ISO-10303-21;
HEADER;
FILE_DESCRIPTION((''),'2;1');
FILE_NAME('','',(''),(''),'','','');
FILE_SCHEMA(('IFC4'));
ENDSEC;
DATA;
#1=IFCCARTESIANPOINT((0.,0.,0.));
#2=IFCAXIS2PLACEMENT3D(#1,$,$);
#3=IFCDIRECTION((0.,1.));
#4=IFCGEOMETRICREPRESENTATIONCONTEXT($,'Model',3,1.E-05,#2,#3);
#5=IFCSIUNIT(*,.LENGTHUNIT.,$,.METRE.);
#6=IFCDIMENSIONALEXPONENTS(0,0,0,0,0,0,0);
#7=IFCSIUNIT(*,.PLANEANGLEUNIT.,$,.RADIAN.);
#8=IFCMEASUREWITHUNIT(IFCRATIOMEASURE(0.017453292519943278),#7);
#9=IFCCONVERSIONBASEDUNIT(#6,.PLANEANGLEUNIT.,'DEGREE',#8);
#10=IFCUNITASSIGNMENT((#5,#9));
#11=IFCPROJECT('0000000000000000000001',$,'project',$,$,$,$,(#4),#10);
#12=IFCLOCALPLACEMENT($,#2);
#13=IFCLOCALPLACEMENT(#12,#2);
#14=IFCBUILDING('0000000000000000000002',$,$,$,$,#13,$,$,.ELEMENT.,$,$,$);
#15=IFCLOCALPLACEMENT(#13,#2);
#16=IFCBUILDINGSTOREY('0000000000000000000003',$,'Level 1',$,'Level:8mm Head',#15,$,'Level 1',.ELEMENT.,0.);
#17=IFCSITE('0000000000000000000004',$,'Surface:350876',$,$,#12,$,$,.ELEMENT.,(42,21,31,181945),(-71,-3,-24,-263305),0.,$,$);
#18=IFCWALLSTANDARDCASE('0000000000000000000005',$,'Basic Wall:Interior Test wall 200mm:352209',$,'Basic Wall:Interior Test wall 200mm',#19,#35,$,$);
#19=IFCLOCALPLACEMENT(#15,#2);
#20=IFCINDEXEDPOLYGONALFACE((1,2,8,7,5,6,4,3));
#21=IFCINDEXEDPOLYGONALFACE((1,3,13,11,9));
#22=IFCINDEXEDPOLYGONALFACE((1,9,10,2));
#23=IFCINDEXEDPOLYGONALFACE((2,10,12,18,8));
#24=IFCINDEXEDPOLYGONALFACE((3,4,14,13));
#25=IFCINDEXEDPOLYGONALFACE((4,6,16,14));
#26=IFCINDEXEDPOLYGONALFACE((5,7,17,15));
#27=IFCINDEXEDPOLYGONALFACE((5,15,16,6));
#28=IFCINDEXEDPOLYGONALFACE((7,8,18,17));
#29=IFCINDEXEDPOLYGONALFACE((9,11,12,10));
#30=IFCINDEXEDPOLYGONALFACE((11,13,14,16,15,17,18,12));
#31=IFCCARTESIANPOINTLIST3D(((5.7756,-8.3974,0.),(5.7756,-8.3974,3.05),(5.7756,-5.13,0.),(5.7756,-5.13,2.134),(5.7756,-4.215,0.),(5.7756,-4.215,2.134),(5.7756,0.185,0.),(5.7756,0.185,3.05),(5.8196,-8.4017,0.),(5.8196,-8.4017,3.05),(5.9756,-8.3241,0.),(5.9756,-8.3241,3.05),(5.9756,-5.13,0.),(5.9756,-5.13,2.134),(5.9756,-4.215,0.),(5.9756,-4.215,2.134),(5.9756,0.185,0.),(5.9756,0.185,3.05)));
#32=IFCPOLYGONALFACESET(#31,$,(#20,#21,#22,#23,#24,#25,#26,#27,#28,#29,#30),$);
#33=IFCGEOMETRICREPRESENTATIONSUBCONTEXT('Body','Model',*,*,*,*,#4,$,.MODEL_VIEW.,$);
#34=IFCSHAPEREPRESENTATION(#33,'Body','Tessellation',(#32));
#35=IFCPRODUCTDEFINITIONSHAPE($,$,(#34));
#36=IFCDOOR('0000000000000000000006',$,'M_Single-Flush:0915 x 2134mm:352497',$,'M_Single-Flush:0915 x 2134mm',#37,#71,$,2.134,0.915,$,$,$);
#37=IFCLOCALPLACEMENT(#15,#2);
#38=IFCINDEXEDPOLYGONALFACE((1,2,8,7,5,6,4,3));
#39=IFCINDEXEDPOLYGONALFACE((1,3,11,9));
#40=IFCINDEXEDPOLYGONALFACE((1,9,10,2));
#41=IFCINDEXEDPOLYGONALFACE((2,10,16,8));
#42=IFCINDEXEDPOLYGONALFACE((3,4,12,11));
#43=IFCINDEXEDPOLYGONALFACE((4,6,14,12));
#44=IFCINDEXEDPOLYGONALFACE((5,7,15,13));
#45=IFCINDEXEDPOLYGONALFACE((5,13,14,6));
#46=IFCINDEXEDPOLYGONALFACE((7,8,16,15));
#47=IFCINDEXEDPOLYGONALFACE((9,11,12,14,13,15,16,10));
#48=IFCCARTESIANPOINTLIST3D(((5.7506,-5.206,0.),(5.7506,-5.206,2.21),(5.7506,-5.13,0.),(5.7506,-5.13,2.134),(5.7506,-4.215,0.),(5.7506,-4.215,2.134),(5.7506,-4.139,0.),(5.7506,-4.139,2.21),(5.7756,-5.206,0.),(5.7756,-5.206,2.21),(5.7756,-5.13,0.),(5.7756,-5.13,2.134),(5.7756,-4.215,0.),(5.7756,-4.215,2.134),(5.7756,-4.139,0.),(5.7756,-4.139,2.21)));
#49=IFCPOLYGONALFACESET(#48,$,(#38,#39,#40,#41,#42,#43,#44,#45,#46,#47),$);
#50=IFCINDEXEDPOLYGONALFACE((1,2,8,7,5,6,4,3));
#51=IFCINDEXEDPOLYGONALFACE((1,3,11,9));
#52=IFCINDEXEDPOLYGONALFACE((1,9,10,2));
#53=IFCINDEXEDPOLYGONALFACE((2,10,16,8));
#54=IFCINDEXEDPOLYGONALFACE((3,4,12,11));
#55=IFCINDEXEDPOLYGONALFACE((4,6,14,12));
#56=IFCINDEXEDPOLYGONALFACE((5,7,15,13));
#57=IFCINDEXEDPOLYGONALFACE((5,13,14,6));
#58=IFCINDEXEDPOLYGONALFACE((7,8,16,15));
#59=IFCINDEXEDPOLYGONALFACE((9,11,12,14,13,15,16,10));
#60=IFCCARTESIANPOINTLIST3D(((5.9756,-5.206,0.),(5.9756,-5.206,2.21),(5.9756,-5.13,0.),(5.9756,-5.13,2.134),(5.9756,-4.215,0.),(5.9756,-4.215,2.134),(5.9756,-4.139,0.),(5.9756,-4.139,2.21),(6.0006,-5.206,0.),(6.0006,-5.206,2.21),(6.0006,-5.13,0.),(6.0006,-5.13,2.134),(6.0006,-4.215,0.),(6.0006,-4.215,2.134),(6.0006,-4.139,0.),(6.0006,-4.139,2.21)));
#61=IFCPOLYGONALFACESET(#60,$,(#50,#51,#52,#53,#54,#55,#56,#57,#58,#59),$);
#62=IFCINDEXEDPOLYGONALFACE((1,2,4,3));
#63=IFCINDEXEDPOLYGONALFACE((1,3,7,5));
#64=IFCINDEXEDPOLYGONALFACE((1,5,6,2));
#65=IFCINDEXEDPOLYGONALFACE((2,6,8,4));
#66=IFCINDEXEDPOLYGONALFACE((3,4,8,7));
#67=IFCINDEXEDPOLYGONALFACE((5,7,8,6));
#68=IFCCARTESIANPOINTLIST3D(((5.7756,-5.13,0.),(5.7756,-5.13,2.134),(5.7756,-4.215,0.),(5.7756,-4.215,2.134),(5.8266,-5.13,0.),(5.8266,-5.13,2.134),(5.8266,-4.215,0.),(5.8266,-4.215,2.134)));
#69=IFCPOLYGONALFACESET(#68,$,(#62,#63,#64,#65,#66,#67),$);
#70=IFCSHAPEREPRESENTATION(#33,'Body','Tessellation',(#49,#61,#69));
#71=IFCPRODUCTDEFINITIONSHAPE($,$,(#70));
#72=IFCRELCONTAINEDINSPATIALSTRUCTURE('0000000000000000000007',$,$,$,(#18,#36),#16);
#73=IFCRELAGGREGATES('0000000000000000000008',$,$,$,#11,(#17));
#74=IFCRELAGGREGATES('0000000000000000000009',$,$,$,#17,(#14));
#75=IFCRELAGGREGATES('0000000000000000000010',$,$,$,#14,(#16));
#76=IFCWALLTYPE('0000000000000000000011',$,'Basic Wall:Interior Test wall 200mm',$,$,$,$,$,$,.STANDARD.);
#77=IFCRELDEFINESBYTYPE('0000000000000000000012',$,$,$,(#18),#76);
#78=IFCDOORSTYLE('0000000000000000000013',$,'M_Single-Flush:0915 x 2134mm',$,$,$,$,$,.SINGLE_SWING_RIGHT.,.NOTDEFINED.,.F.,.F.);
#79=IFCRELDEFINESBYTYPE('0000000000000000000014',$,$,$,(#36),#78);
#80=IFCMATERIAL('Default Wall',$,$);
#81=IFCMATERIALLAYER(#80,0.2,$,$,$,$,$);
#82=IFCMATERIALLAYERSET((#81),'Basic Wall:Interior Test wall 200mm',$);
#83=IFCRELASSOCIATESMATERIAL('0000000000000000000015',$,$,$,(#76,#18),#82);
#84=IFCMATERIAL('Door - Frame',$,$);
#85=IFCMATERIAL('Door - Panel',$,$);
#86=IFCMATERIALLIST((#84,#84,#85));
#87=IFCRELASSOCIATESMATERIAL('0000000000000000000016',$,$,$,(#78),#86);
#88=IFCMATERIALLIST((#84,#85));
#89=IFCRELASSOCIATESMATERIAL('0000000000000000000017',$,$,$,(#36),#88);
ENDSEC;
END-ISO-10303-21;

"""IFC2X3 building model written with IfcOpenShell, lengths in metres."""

from ifc_helpers import new_model, entity, si_unit, converted_unit, direction, frame, frame_2d, origin, place, context, subcontext, project, spatial, polyline, rectangle, outline, extrude, clip, bounded_halfspace, source, transform, mapped, material, material_list, layer, layer_set, layer_usage, type_object, type_shapes, element, fill, save


model = new_model("IFC2X3")

# Units and contexts
model_context = context("Model", 3, precision=1e-05, world=origin(), true_north=direction((0.0, 1.0)))
body_context = subcontext(model_context, "Body", "Model", "MODEL_VIEW")
ifc_project = project(units=[si_unit("LENGTHUNIT", "METRE"), converted_unit("PLANEANGLEUNIT", "DEGREE", entity("IfcRatioMeasure", 0.017453292519943278), si_unit("PLANEANGLEUNIT", "RADIAN"), dimensions=[0, 0, 0, 0, 0, 0, 0])], contexts=[model_context])

# Site, building, storey
site_placement = place(None, origin())
site = spatial("IfcSite", under=ifc_project, at=site_placement, Name="Surface:350876", CompositionType="ELEMENT", RefLatitude=(42, 21, 31, 181945), RefLongitude=(-71, -3, -24, -263305), RefElevation=0.0)
building_placement = place(site_placement, origin())
building = spatial("IfcBuilding", under=site, at=building_placement, CompositionType="ELEMENT")
storey_placement = place(building_placement, origin())
storey = spatial("IfcBuildingStorey", under=building, at=storey_placement, Name="Level 1", ObjectType="Level:8mm Head", LongName="Level 1", CompositionType="ELEMENT", Elevation=0.0)

# Shared definitions
ifc_material_1 = material(Name="Default Wall")

# Shared definitions
ifc_layer_1 = layer(ifc_material_1, 0.2)
ifc_layer_set_1 = layer_set([ifc_layer_1], Name="Basic Wall:Interior Test wall 200mm")
wall_type_1 = type_object("IfcWallType", Name="Basic Wall:Interior Test wall 200mm", PredefinedType="STANDARD", material=ifc_layer_set_1)

# Wall, opening, door
ifc_layer_usage_1 = layer_usage(ifc_layer_set_1, "AXIS2", "NEGATIVE", 0.1)
wall_1_placement = place(storey_placement, frame((5.8756, -8.3974, 0.0), z_axis=(0.0, 0.0, 1.0), x_axis=(0.0, 1.0, 0.0)))
wall_1 = element("IfcWallStandardCase", 1, at=wall_1_placement, inside=storey, type_object=wall_type_1, material=ifc_layer_usage_1, Name="Basic Wall:Interior Test wall 200mm:352209", ObjectType="Basic Wall:Interior Test wall 200mm", context=body_context, shape_type="Clipping", body=[
    clip(extrude(outline(polyline([(0.0733, -0.1), (8.5824, -0.1), (8.5824, 0.1), (4.4824, 0.1), (4.2824, 0.1), (0.0, 0.1), (-0.0043, 0.056), (0.0733, -0.1)])), origin(), (0.0, 0.0, 1.0), 3.05), bounded_halfspace(frame((0.0733, -0.1, 3.05), z_axis=(0.0, 0.0, -1.0), x_axis=(0.97437, -0.224951, 0.0)), True, frame((0.0733, -0.1, 3.05)), polyline([(0.0, 0.0), (8.5091, 0.0), (8.5091, 0.2), (4.4091, 0.2), (4.2091, 0.2), (-0.0733, 0.2), (-0.0776, 0.156), (0.0, 0.0)]))),
])
opening_1_placement = place(wall_1_placement, frame((3.2674, -0.1, 0.0)))
opening_1 = element("IfcOpeningElement", 2, at=opening_1_placement, cuts=wall_1, ObjectType="Opening", context=body_context, shape_type="SweptSolid", body=[
    extrude(rectangle(XDim=0.915, YDim=2.134, at=frame_2d((1.067, 0.4575), x_axis=(0.0, 1.0))), frame((0.0, 0.0, 0.0), z_axis=(0.0, 1.0, 0.0), x_axis=(0.0, 0.0, 1.0)), (0.0, 0.0, 1.0), 0.2),
])
ifc_material_2 = material(Name="Door - Frame")
ifc_material_3 = material(Name="Door - Panel")
ifc_material_list_1 = material_list([ifc_material_2, ifc_material_3])
ifc_material_list_2 = material_list([ifc_material_2, ifc_material_2, ifc_material_3])
door_style = type_object("IfcDoorStyle", Name="M_Single-Flush:0915 x 2134mm", ConstructionType="NOTDEFINED", OperationType="SINGLE_SWING_RIGHT", ParameterTakesPrecedence=False, Sizeable=False, material=ifc_material_list_2)
shared_shape_1 = source(origin(), body_context, "Body", "SweptSolid", [
    extrude(outline(polyline([(-0.5335, -1.124), (0.5335, -1.124), (0.5335, 1.086), (0.4575, 1.086), (0.4575, -1.048), (-0.4575, -1.048), (-0.4575, 1.086), (-0.5335, 1.086), (-0.5335, -1.124)])), frame((0.4575, 0.2, 1.086), z_axis=(0.0, 1.0, 0.0), x_axis=(1.0, 0.0, 0.0)), (0.0, 0.0, 1.0), 0.025),
    extrude(outline(polyline([(-1.124, -0.5335), (1.086, -0.5335), (1.086, -0.4575), (-1.048, -0.4575), (-1.048, 0.4575), (1.086, 0.4575), (1.086, 0.5335), (-1.124, 0.5335), (-1.124, -0.5335)])), frame((0.4575, -0.025, 1.086), z_axis=(0.0, 1.0, 0.0), x_axis=(0.0, 0.0, -1.0)), (0.0, 0.0, 1.0), 0.025),
    extrude(rectangle(XDim=0.051, YDim=0.915, at=frame_2d((0.0, 0.0), x_axis=(1.0, 0.0))), frame((0.4575, 0.1745, 0.0), z_axis=(0.0, 0.0, 1.0), x_axis=(0.0, 1.0, 0.0)), (0.0, 0.0, 1.0), 2.134),
])
type_shapes(door_style, [shared_shape_1])
door_placement = place(opening_1_placement, origin())
door = element("IfcDoor", 3, at=door_placement, inside=storey, type_object=door_style, material=ifc_material_list_1, Name="M_Single-Flush:0915 x 2134mm:352497", ObjectType="M_Single-Flush:0915 x 2134mm", OverallHeight=2.134, OverallWidth=0.915, context=body_context, shape_type="MappedRepresentation", body=[
    mapped(shared_shape_1, transform((0.0, 0.0, 0.0), scale=1.0)),
])
fill(opening_1, door)

save(model, "model.ifc")
